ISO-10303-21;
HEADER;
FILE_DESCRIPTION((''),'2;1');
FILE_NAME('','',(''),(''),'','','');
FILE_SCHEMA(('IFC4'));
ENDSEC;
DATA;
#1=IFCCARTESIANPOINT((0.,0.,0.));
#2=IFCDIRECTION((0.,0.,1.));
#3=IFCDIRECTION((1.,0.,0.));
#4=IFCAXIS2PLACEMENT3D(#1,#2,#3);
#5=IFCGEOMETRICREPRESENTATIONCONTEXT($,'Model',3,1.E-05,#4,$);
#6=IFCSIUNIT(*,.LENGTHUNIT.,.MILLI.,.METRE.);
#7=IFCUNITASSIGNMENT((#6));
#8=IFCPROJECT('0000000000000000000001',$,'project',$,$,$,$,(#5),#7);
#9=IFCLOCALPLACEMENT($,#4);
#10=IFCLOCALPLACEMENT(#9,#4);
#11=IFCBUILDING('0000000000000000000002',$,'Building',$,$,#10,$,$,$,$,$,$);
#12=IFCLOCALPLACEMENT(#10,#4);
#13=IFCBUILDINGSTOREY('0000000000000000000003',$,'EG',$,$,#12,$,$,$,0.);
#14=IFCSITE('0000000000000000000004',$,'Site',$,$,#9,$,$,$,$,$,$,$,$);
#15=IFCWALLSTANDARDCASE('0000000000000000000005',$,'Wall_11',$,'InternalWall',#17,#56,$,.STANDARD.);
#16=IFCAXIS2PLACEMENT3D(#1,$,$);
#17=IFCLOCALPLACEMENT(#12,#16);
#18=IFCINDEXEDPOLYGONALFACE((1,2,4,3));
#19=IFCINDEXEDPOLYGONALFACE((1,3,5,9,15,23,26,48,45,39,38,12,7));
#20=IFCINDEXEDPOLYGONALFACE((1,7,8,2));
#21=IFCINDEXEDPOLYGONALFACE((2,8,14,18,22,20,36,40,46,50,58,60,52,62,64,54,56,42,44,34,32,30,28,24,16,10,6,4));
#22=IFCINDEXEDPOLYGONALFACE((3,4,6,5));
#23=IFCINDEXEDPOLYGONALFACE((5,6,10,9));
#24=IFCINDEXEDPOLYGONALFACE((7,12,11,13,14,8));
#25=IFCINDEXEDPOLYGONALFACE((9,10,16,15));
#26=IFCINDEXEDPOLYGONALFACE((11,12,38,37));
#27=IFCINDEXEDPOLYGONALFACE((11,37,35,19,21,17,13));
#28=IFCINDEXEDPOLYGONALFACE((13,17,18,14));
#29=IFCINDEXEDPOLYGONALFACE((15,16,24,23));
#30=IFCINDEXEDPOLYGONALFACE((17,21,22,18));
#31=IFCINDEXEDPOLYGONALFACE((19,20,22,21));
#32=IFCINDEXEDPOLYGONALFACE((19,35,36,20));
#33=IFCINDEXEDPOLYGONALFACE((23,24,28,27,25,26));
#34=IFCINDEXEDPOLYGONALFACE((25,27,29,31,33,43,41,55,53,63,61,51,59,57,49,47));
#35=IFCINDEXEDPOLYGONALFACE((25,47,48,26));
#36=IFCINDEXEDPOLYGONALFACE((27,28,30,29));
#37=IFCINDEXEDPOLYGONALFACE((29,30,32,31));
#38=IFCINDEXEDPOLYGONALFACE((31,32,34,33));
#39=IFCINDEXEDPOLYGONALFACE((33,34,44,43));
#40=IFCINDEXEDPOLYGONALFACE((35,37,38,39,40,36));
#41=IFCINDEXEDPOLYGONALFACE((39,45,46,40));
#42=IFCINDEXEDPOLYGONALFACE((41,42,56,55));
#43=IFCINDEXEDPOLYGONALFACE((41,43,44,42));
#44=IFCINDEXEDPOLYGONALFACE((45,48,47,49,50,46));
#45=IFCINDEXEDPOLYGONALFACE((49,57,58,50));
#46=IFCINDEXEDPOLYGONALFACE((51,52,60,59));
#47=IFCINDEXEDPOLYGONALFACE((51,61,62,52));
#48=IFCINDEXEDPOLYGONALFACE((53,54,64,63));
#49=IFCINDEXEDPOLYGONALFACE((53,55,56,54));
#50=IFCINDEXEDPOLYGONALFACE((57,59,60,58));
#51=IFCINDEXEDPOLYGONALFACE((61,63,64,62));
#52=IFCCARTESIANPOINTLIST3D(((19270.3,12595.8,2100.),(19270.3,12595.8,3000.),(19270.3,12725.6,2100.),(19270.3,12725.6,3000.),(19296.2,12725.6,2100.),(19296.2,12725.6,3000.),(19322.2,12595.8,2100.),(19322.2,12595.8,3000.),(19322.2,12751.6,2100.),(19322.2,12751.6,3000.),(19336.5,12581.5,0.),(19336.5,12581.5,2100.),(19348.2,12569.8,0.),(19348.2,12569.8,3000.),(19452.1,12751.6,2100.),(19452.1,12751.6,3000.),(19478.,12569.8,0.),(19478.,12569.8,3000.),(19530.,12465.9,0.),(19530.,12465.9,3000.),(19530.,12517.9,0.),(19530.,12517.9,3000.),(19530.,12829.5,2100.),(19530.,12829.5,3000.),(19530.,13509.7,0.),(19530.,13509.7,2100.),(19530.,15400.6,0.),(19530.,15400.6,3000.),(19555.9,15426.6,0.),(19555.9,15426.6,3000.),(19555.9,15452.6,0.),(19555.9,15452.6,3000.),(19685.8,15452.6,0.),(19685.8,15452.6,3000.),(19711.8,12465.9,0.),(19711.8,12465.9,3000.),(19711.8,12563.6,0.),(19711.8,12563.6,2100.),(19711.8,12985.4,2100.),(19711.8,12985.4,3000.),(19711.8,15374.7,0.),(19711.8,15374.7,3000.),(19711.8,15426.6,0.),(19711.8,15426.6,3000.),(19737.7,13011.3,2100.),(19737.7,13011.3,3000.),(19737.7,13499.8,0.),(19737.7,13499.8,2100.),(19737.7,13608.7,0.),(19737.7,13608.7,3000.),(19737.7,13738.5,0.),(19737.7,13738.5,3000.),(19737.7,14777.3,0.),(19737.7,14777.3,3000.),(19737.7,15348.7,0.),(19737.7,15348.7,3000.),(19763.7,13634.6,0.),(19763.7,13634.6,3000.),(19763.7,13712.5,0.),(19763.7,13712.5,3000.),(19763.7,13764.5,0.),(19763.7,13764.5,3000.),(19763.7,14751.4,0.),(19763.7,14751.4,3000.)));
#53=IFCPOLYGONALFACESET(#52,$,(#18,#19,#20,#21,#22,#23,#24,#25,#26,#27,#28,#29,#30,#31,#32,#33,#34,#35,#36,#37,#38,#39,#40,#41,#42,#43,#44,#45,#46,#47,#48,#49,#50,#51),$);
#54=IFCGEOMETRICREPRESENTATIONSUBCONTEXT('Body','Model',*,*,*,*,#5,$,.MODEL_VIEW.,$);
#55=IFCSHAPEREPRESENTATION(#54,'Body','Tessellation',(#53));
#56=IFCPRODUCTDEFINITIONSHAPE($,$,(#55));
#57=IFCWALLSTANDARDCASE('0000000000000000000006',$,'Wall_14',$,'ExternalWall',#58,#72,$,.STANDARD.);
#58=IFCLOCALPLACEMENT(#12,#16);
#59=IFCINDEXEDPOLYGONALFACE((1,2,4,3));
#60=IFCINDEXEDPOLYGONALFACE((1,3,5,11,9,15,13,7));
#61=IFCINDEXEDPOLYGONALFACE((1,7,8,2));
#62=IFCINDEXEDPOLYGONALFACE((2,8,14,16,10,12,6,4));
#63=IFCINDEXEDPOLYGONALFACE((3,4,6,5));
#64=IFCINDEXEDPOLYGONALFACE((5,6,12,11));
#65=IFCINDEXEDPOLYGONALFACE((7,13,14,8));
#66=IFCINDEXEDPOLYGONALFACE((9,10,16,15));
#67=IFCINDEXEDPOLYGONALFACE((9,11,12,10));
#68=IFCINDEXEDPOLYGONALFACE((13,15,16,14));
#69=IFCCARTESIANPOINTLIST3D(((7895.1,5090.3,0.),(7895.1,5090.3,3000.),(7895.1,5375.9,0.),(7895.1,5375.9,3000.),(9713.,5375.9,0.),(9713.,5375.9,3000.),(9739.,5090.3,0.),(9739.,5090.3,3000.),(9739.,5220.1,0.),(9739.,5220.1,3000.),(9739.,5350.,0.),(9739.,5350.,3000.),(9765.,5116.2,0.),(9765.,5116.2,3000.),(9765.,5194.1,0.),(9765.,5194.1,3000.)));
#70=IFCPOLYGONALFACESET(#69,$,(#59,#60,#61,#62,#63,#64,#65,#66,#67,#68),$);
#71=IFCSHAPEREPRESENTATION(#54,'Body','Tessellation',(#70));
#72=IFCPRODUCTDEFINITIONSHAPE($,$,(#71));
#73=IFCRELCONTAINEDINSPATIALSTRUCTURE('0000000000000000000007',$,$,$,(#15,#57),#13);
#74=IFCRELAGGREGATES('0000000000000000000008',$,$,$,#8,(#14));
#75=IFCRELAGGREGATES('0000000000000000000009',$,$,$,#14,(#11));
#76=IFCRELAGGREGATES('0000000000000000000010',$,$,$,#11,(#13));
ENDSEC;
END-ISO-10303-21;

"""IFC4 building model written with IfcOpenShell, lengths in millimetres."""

from ifc_helpers import new_model, si_unit, frame, origin_with_axes, place, context, subcontext, project, spatial, polyline, rectangle, outline, extrude, element, save


model = new_model("IFC4")

# Units and contexts
model_context = context("Model", 3, precision=1e-05, world=origin_with_axes())
body_context = subcontext(model_context, "Body", "Model", "MODEL_VIEW")
ifc_project = project(units=[si_unit("LENGTHUNIT", "METRE", prefix="MILLI")], contexts=[model_context])

# Site, building, storey
site_placement = place(None, origin_with_axes())
site = spatial("IfcSite", under=ifc_project, at=site_placement, Name="Site")
building_placement = place(site_placement, origin_with_axes())
building = spatial("IfcBuilding", under=site, at=building_placement, Name="Building")
storey_placement = place(building_placement, origin_with_axes())
storey = spatial("IfcBuildingStorey", under=building, at=storey_placement, Name="EG", Elevation=0.0)

# Walls, openings
wall_1_placement = place(storey_placement, origin_with_axes())
wall_1 = element("IfcWallStandardCase", 1, at=wall_1_placement, inside=storey, Name="Wall_11", ObjectType="InternalWall", PredefinedType="STANDARD", context=body_context, shape_type="SweptSolid", body=[
    extrude(outline(polyline([(19530.0, 12465.9, 0.0), (19530.0, 12517.9, 0.0), (19478.0, 12569.8, 0.0), (19348.2, 12569.8, 0.0), (19322.2, 12595.8, 0.0), (19270.3, 12595.8, 0.0), (19270.3, 12725.6, 0.0), (19296.2, 12725.6, 0.0), (19322.2, 12751.6, 0.0), (19452.1, 12751.6, 0.0), (19530.0, 12829.5, 0.0), (19530.0, 15400.6, 0.0), (19555.9, 15426.6, 0.0), (19555.9, 15452.6, 0.0), (19685.8, 15452.6, 0.0), (19711.8, 15426.6, 0.0), (19711.8, 15374.7, 0.0), (19737.7, 15348.7, 0.0), (19737.7, 14777.3, 0.0), (19763.7, 14751.4, 0.0), (19763.7, 13764.5, 0.0), (19737.7, 13738.5, 0.0), (19763.7, 13712.5, 0.0), (19763.7, 13634.6, 0.0), (19737.7, 13608.7, 0.0), (19737.7, 13011.3, 0.0), (19711.8, 12985.4, 0.0), (19711.8, 12465.9, 0.0), (19530.0, 12465.9, 0.0)])), origin_with_axes(), (0.0, 0.0, 1.0), 3000.0),
])
opening_1_placement = place(wall_1_placement, origin_with_axes())
element("IfcOpeningElement", 2, at=opening_1_placement, inside=storey, cuts=wall_1, context=body_context, shape_type="SweptSolid", body=[
    extrude(rectangle(XDim=936.4, YDim=453.4), frame((19512.3, 13041.9, 0.0), z_axis=(0.0, 0.0, 1.0), x_axis=(-0.047565, -0.998868, 0.0)), (0.0, 0.0, 1.0), 2100.0),
])
wall_2_placement = place(storey_placement, origin_with_axes())
wall_2 = element("IfcWallStandardCase", 3, at=wall_2_placement, inside=storey, Name="Wall_14", ObjectType="ExternalWall", PredefinedType="STANDARD", context=body_context, shape_type="SweptSolid", body=[
    extrude(outline(polyline([(7895.1, 5090.3, 0.0), (7895.1, 5375.9, 0.0), (9713.0, 5375.9, 0.0), (9739.0, 5350.0, 0.0), (9739.0, 5220.1, 0.0), (9765.0, 5194.1, 0.0), (9765.0, 5116.2, 0.0), (9739.0, 5090.3, 0.0), (7895.1, 5090.3, 0.0)])), origin_with_axes(), (0.0, 0.0, 1.0), 3000.0),
])
opening_2_placement = place(wall_2_placement, origin_with_axes())
element("IfcOpeningElement", 4, at=opening_2_placement, inside=storey, cuts=wall_2, context=body_context, shape_type="SweptSolid", body=[
    extrude(rectangle(XDim=1200.0, YDim=285.7), frame((10439.6, 5233.0, 50.0), z_axis=(0.0, 0.0, 1.0), x_axis=(1.0, 0.0, 0.0)), (0.0, 0.0, 1.0), 1950.0),
])

save(model, "model.ifc")
